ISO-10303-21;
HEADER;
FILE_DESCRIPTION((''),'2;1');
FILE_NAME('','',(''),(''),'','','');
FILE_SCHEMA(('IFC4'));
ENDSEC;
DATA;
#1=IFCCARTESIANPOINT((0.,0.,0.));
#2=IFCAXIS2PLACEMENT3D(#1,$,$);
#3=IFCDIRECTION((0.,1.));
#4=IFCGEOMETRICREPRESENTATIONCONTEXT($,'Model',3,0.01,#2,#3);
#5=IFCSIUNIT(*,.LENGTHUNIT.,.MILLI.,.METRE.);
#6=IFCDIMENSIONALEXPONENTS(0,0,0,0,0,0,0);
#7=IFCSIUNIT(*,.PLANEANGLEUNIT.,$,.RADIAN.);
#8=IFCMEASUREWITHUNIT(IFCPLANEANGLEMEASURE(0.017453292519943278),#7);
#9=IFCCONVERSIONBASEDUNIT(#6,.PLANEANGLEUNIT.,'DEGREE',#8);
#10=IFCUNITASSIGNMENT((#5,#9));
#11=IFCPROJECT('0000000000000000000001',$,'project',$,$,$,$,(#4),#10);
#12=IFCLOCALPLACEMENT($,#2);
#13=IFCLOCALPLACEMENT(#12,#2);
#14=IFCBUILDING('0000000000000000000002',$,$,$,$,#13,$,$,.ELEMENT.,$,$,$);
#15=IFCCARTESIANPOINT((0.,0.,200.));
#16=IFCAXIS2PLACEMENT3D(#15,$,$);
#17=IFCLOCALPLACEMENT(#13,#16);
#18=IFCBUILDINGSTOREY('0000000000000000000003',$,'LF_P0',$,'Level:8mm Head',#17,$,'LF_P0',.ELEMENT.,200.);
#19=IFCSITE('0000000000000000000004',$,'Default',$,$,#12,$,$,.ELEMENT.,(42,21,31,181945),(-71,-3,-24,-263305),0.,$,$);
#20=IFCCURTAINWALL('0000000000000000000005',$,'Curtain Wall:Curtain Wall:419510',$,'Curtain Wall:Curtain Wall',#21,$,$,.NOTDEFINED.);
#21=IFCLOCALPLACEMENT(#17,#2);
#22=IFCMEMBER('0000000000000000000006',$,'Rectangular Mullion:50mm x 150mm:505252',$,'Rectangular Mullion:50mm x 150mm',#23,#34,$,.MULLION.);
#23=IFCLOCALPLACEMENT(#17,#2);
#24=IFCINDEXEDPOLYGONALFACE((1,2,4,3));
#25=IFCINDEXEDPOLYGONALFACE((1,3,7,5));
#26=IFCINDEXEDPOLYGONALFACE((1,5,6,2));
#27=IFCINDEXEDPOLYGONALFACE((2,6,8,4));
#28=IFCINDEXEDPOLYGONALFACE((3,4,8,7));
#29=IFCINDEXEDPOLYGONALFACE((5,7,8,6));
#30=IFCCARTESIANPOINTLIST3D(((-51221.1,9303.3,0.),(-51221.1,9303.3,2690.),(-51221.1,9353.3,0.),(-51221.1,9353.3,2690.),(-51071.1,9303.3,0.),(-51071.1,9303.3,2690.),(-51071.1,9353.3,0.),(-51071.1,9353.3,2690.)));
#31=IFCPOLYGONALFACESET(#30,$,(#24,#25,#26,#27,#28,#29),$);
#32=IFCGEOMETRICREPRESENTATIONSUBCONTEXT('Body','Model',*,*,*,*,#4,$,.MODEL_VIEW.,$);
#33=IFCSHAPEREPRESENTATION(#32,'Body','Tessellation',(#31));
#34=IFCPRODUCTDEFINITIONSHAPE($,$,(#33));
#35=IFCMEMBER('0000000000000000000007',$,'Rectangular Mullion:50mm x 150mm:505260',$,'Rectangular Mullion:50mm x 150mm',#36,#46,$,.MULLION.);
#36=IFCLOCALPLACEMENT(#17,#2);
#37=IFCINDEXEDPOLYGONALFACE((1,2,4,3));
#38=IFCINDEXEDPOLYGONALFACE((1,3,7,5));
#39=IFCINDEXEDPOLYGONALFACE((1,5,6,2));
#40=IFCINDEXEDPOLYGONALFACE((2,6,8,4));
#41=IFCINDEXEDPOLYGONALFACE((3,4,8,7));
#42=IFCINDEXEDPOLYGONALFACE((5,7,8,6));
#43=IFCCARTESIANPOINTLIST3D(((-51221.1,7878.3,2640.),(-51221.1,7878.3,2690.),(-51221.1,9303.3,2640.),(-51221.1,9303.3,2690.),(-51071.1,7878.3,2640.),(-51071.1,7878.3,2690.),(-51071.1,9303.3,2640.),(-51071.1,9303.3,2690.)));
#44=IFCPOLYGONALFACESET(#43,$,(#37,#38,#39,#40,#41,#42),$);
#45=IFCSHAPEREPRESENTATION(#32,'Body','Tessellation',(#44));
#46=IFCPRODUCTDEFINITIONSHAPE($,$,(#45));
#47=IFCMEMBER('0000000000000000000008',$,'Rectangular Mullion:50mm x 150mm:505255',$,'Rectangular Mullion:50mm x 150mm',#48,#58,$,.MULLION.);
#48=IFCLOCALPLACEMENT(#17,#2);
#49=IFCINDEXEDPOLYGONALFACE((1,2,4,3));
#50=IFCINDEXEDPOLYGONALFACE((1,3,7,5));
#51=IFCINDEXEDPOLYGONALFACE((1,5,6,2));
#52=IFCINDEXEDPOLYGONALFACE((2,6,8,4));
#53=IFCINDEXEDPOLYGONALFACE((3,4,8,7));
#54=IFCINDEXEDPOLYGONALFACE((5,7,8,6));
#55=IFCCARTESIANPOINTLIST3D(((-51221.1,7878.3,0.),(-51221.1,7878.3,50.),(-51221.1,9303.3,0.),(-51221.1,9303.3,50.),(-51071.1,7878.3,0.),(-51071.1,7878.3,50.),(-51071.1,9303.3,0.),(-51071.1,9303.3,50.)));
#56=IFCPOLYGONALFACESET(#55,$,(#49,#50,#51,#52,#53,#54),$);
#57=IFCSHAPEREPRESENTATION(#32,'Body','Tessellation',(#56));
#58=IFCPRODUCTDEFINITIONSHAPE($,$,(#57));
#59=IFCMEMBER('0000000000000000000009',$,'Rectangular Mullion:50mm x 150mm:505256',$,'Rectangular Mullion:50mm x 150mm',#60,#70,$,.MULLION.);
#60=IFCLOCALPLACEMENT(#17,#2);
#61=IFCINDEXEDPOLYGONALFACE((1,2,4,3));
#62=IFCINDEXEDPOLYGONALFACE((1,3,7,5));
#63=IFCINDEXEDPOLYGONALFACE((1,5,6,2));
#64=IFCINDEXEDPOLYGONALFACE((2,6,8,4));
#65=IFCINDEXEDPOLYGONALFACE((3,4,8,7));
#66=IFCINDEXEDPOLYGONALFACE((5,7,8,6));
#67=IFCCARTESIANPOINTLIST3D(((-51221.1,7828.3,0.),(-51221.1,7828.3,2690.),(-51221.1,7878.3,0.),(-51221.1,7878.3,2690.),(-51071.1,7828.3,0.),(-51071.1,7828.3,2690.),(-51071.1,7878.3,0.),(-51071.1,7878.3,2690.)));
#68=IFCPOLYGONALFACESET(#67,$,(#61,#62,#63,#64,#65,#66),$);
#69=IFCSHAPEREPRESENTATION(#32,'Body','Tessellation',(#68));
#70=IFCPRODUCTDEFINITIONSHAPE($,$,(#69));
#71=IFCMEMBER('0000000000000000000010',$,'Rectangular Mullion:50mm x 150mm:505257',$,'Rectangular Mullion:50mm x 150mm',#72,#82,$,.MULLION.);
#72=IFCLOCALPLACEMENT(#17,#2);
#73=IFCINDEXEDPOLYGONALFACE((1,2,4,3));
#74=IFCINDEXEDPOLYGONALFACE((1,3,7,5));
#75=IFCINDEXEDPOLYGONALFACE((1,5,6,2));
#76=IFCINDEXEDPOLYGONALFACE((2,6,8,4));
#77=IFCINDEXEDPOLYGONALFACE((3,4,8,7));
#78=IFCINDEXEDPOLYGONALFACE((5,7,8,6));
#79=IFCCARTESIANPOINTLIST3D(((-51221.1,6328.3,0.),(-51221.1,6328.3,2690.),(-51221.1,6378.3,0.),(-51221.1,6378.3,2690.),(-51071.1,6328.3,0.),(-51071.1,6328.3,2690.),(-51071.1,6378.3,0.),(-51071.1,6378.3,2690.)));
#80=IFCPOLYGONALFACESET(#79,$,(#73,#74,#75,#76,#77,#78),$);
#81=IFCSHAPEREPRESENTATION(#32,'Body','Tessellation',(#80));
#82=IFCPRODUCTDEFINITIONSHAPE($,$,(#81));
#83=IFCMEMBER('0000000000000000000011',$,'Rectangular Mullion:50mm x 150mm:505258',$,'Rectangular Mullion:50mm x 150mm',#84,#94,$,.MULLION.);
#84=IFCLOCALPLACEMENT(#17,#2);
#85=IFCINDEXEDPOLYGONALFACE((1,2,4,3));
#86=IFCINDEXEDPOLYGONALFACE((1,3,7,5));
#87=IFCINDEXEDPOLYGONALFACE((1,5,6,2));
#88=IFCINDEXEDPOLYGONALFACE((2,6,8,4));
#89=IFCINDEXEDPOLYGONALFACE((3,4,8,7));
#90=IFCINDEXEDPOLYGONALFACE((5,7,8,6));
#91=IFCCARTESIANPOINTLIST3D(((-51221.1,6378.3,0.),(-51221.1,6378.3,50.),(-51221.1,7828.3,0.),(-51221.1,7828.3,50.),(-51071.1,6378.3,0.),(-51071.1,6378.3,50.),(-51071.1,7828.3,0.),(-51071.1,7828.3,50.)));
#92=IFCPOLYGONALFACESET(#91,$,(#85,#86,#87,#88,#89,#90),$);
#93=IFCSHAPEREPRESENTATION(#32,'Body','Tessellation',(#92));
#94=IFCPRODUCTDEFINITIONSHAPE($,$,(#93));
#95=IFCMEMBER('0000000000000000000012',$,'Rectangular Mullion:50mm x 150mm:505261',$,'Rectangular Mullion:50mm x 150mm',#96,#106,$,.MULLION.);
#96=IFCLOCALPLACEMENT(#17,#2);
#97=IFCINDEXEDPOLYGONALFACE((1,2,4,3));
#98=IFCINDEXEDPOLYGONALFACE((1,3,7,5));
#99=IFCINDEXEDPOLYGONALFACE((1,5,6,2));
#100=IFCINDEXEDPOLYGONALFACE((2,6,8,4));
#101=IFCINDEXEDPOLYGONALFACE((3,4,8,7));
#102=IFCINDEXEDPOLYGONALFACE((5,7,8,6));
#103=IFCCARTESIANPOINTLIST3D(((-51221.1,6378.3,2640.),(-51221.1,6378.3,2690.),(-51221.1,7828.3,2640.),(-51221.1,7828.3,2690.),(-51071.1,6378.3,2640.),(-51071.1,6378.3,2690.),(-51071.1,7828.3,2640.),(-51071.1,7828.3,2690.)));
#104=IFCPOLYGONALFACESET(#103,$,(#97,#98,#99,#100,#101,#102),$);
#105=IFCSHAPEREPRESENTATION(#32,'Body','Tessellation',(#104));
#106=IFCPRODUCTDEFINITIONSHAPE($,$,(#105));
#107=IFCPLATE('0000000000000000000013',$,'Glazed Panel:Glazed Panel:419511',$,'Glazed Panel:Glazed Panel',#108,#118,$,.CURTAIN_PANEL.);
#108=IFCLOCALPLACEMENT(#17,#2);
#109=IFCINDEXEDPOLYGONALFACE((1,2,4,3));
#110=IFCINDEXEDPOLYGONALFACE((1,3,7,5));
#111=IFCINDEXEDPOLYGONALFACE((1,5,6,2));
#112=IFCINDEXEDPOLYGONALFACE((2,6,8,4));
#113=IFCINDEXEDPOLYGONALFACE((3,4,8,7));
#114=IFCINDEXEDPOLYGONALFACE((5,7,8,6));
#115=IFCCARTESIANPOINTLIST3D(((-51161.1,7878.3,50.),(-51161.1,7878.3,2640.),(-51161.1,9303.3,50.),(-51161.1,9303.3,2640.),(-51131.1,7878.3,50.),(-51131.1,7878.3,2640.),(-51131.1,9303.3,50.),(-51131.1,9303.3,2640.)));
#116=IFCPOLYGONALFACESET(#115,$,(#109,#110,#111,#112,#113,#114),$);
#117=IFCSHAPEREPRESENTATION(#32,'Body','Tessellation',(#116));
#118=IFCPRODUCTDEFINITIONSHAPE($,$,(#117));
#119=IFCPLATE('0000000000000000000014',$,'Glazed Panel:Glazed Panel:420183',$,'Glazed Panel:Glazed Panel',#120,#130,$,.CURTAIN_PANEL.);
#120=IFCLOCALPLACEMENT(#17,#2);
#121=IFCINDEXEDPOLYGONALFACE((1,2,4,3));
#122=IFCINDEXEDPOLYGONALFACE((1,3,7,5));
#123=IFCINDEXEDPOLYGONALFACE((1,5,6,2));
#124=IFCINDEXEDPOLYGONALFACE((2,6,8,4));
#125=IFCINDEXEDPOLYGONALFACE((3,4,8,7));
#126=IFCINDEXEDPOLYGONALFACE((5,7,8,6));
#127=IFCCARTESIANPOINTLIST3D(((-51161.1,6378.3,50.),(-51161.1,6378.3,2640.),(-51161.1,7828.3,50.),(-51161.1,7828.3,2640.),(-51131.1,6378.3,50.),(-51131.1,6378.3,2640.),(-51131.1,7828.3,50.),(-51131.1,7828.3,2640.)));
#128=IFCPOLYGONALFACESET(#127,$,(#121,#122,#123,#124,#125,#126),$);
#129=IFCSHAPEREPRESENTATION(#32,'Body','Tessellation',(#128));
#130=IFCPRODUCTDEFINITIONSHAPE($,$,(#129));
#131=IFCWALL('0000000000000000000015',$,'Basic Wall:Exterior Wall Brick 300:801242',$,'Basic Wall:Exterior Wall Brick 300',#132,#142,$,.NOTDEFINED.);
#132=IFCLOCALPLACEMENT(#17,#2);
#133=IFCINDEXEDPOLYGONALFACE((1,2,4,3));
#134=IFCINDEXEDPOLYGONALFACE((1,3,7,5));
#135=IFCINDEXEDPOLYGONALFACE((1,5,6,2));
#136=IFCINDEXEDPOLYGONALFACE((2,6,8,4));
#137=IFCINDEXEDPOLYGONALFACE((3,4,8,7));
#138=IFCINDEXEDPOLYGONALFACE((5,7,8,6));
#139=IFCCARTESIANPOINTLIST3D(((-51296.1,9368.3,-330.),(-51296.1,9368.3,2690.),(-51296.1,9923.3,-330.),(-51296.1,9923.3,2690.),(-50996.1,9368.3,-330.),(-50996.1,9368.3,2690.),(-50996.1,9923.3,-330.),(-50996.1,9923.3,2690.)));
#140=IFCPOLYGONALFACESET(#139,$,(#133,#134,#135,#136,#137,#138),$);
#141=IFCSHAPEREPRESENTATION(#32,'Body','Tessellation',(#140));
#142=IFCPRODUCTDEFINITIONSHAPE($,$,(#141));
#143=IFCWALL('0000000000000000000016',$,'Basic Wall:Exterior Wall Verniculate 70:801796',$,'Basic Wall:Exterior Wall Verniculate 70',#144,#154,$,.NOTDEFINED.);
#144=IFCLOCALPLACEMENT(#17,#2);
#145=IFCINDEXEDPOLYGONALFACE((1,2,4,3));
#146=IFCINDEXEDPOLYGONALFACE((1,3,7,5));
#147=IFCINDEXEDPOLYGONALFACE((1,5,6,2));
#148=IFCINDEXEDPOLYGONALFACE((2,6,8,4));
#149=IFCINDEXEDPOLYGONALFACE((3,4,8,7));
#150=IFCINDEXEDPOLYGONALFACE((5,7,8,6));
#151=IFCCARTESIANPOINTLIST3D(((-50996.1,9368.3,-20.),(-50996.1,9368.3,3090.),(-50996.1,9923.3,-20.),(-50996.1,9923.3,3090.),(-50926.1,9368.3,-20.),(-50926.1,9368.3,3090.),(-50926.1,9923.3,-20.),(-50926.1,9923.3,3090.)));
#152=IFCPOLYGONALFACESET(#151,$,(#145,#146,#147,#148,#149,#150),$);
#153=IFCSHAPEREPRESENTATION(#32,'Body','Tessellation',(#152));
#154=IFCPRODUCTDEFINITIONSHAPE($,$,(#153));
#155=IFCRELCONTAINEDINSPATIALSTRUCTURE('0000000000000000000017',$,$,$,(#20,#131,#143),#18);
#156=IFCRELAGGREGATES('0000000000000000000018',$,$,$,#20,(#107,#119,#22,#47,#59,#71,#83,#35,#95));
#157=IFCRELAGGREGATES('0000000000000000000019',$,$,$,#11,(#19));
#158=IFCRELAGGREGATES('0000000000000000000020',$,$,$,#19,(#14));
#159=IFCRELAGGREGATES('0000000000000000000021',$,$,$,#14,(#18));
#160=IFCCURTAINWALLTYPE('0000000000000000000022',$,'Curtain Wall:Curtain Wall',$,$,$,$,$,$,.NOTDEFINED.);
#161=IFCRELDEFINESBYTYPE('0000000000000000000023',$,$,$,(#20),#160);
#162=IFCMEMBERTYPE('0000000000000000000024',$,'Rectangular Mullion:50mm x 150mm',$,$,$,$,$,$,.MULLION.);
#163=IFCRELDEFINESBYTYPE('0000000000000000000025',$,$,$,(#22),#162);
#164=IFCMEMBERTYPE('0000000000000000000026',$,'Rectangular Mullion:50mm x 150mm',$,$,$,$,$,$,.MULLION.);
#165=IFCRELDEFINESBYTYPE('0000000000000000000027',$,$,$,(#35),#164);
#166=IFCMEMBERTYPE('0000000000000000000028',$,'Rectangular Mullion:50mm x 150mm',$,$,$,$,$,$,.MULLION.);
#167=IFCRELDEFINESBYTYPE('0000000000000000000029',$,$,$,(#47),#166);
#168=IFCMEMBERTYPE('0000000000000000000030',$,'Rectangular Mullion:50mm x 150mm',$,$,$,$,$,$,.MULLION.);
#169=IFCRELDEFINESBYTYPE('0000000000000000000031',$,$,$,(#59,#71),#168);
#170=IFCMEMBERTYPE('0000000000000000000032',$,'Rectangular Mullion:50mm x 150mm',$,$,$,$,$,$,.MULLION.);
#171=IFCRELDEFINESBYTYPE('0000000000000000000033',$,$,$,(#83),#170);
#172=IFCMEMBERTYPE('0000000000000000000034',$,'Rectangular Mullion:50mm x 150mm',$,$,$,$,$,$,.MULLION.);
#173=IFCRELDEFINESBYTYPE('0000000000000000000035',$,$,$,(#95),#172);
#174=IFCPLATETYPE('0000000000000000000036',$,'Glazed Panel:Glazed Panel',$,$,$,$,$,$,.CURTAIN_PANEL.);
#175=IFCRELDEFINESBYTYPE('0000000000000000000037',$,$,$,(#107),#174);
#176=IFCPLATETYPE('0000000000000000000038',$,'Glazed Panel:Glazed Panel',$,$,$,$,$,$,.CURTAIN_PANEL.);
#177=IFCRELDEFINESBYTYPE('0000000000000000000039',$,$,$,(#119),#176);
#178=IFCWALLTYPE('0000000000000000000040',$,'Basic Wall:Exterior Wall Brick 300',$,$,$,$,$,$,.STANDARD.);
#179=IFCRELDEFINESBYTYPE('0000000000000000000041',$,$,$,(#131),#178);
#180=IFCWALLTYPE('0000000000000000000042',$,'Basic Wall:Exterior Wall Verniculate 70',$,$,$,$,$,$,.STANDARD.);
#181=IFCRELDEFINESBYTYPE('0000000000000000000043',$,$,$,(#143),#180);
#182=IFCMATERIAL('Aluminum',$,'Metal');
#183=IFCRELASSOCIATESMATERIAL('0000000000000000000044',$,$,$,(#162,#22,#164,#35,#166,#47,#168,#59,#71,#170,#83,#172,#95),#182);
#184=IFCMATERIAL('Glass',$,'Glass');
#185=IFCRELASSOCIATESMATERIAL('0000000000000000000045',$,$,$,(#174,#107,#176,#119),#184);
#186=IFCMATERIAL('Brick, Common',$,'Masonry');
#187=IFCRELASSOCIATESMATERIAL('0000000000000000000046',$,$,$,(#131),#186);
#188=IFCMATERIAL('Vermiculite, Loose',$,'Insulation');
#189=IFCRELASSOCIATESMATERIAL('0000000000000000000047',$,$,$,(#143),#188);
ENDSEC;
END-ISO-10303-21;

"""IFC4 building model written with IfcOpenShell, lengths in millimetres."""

from ifc_helpers import new_model, entity, si_unit, converted_unit, direction, frame, origin, place, context, subcontext, project, spatial, indexed_curve, outline, extrude, source, transform, mapped, material, type_object, type_shapes, element, aggregate, save


model = new_model("IFC4")

# Units and contexts
model_context = context("Model", 3, precision=0.01, world=origin(), true_north=direction((0.0, 1.0)))
body_context = subcontext(model_context, "Body", "Model", "MODEL_VIEW")
ifc_project = project(units=[si_unit("LENGTHUNIT", "METRE", prefix="MILLI"), converted_unit("PLANEANGLEUNIT", "DEGREE", entity("IfcPlaneAngleMeasure", 0.017453292519943278), si_unit("PLANEANGLEUNIT", "RADIAN"), dimensions=[0, 0, 0, 0, 0, 0, 0])], contexts=[model_context])

# Site, building, storey
site_placement = place(None, origin())
site = spatial("IfcSite", under=ifc_project, at=site_placement, Name="Default", CompositionType="ELEMENT", RefLatitude=(42, 21, 31, 181945), RefLongitude=(-71, -3, -24, -263305), RefElevation=0.0)
building_placement = place(site_placement, origin())
building = spatial("IfcBuilding", under=site, at=building_placement, CompositionType="ELEMENT")
storey_placement = place(building_placement, frame((0.0, 0.0, 200.0)))
storey = spatial("IfcBuildingStorey", under=building, at=storey_placement, Name="LF_P0", ObjectType="Level:8mm Head", LongName="LF_P0", CompositionType="ELEMENT", Elevation=200.0)

# Curtain wall, members, plates
curtain_wall_type = type_object("IfcCurtainWallType", Name="Curtain Wall:Curtain Wall", PredefinedType="NOTDEFINED")
curtain_wall_placement = place(storey_placement, frame((0.0, 0.0, -200.0)))
curtain_wall = element("IfcCurtainWall", 1, at=curtain_wall_placement, inside=storey, type_object=curtain_wall_type, Name="Curtain Wall:Curtain Wall:419510", ObjectType="Curtain Wall:Curtain Wall", PredefinedType="NOTDEFINED")
ifc_material_1 = material(Name="Aluminum", Category="Metal")
member_type_1 = type_object("IfcMemberType", Name="Rectangular Mullion:50mm x 150mm", PredefinedType="MULLION", material=ifc_material_1)
shared_shape_1 = source(origin(), body_context, "Body", "SweptSolid", [
    extrude(outline(indexed_curve([(-25.0, -75.0), (25.0, -75.0), (25.0, 75.0), (-25.0, 75.0), (-25.0, -75.0)], self_intersect=False)), frame((-25.0, 0.0, -2690.0), z_axis=(0.0, 0.0, 1.0), x_axis=(-1.0, 0.0, 0.0)), (0.0, 0.0, 1.0), 2690.0),
])
type_shapes(member_type_1, [shared_shape_1])
member_1_placement = place(curtain_wall_placement, frame((-51146.1, 9353.3, 2890.0), z_axis=(0.0, 0.0, 1.0), x_axis=(0.0, 1.0, 0.0)))
member_1 = element("IfcMember", 2, at=member_1_placement, type_object=member_type_1, material=ifc_material_1, Name="Rectangular Mullion:50mm x 150mm:505252", ObjectType="Rectangular Mullion:50mm x 150mm", PredefinedType="MULLION", context=body_context, shape_type="MappedRepresentation", body=[
    mapped(shared_shape_1, transform((0.0, 0.0, 0.0), scale=1.0)),
])
member_type_2 = type_object("IfcMemberType", Name="Rectangular Mullion:50mm x 150mm", PredefinedType="MULLION", material=ifc_material_1)
shared_shape_2 = source(origin(), body_context, "Body", "SweptSolid", [
    extrude(outline(indexed_curve([(-25.0, -75.0), (25.0, -75.0), (25.0, 75.0), (-25.0, 75.0), (-25.0, -75.0)], self_intersect=False)), frame((-25.0, 0.0, -1425.0), z_axis=(0.0, 0.0, 1.0), x_axis=(-1.0, 0.0, 0.0)), (0.0, 0.0, 1.0), 1425.0),
])
type_shapes(member_type_2, [shared_shape_2])
member_2_placement = place(curtain_wall_placement, frame((-51146.1, 7878.3, 2890.0), z_axis=(0.0, -1.0, 0.0), x_axis=(0.0, 0.0, 1.0)))
member_2 = element("IfcMember", 3, at=member_2_placement, type_object=member_type_2, material=ifc_material_1, Name="Rectangular Mullion:50mm x 150mm:505260", ObjectType="Rectangular Mullion:50mm x 150mm", PredefinedType="MULLION", context=body_context, shape_type="MappedRepresentation", body=[
    mapped(shared_shape_2, transform((0.0, 0.0, 0.0), scale=1.0)),
])
member_type_3 = type_object("IfcMemberType", Name="Rectangular Mullion:50mm x 150mm", PredefinedType="MULLION", material=ifc_material_1)
shared_shape_3 = source(origin(), body_context, "Body", "SweptSolid", [
    extrude(outline(indexed_curve([(-25.0, -75.0), (25.0, -75.0), (25.0, 75.0), (-25.0, 75.0), (-25.0, -75.0)], self_intersect=False)), frame((-25.0, 0.0, -1425.0), z_axis=(0.0, 0.0, 1.0), x_axis=(-1.0, 0.0, 0.0)), (0.0, 0.0, 1.0), 1425.0),
])
type_shapes(member_type_3, [shared_shape_3])
member_3_placement = place(curtain_wall_placement, frame((-51146.1, 9303.3, 200.0), z_axis=(0.0, 1.0, 0.0), x_axis=(0.0, 0.0, -1.0)))
member_3 = element("IfcMember", 4, at=member_3_placement, type_object=member_type_3, material=ifc_material_1, Name="Rectangular Mullion:50mm x 150mm:505255", ObjectType="Rectangular Mullion:50mm x 150mm", PredefinedType="MULLION", context=body_context, shape_type="MappedRepresentation", body=[
    mapped(shared_shape_3, transform((0.0, 0.0, 0.0), scale=1.0)),
])
member_type_4 = type_object("IfcMemberType", Name="Rectangular Mullion:50mm x 150mm", PredefinedType="MULLION", material=ifc_material_1)
shared_shape_4 = source(origin(), body_context, "Body", "SweptSolid", [
    extrude(outline(indexed_curve([(-25.0, -75.0), (25.0, -75.0), (25.0, 75.0), (-25.0, 75.0), (-25.0, -75.0)], self_intersect=False)), frame((0.0, 0.0, -2690.0), z_axis=(0.0, 0.0, 1.0), x_axis=(-1.0, 0.0, 0.0)), (0.0, 0.0, 1.0), 2690.0),
])
type_shapes(member_type_4, [shared_shape_4])
member_4_placement = place(curtain_wall_placement, frame((-51146.1, 7853.3, 200.0), z_axis=(0.0, 0.0, -1.0), x_axis=(0.0, -1.0, 0.0)))
member_4 = element("IfcMember", 5, at=member_4_placement, type_object=member_type_4, material=ifc_material_1, Name="Rectangular Mullion:50mm x 150mm:505256", ObjectType="Rectangular Mullion:50mm x 150mm", PredefinedType="MULLION", context=body_context, shape_type="MappedRepresentation", body=[
    mapped(shared_shape_4, transform((0.0, 0.0, 0.0), scale=1.0)),
])
member_5_placement = place(curtain_wall_placement, frame((-51146.1, 6353.3, 200.0), z_axis=(0.0, 0.0, -1.0), x_axis=(0.0, -1.0, 0.0)))
member_5 = element("IfcMember", 6, at=member_5_placement, type_object=member_type_4, material=ifc_material_1, Name="Rectangular Mullion:50mm x 150mm:505257", ObjectType="Rectangular Mullion:50mm x 150mm", PredefinedType="MULLION", context=body_context, shape_type="MappedRepresentation", body=[
    mapped(shared_shape_4, transform((0.0, 0.0, 0.0), scale=1.0)),
])
member_type_5 = type_object("IfcMemberType", Name="Rectangular Mullion:50mm x 150mm", PredefinedType="MULLION", material=ifc_material_1)
shared_shape_5 = source(origin(), body_context, "Body", "SweptSolid", [
    extrude(outline(indexed_curve([(-25.0, -75.0), (25.0, -75.0), (25.0, 75.0), (-25.0, 75.0), (-25.0, -75.0)], self_intersect=False)), frame((-25.0, 0.0, -1450.0), z_axis=(0.0, 0.0, 1.0), x_axis=(-1.0, 0.0, 0.0)), (0.0, 0.0, 1.0), 1450.0),
])
type_shapes(member_type_5, [shared_shape_5])
member_6_placement = place(curtain_wall_placement, frame((-51146.1, 7828.3, 200.0), z_axis=(0.0, 1.0, 0.0), x_axis=(0.0, 0.0, -1.0)))
member_6 = element("IfcMember", 7, at=member_6_placement, type_object=member_type_5, material=ifc_material_1, Name="Rectangular Mullion:50mm x 150mm:505258", ObjectType="Rectangular Mullion:50mm x 150mm", PredefinedType="MULLION", context=body_context, shape_type="MappedRepresentation", body=[
    mapped(shared_shape_5, transform((0.0, 0.0, 0.0), scale=1.0)),
])
member_type_6 = type_object("IfcMemberType", Name="Rectangular Mullion:50mm x 150mm", PredefinedType="MULLION", material=ifc_material_1)
shared_shape_6 = source(origin(), body_context, "Body", "SweptSolid", [
    extrude(outline(indexed_curve([(-25.0, -75.0), (25.0, -75.0), (25.0, 75.0), (-25.0, 75.0), (-25.0, -75.0)], self_intersect=False)), frame((-25.0, 0.0, -1450.0), z_axis=(0.0, 0.0, 1.0), x_axis=(-1.0, 0.0, 0.0)), (0.0, 0.0, 1.0), 1450.0),
])
type_shapes(member_type_6, [shared_shape_6])
member_7_placement = place(curtain_wall_placement, frame((-51146.1, 6378.3, 2890.0), z_axis=(0.0, -1.0, 0.0), x_axis=(0.0, 0.0, 1.0)))
member_7 = element("IfcMember", 8, at=member_7_placement, type_object=member_type_6, material=ifc_material_1, Name="Rectangular Mullion:50mm x 150mm:505261", ObjectType="Rectangular Mullion:50mm x 150mm", PredefinedType="MULLION", context=body_context, shape_type="MappedRepresentation", body=[
    mapped(shared_shape_6, transform((0.0, 0.0, 0.0), scale=1.0)),
])
ifc_material_2 = material(Name="Glass", Category="Glass")
plate_type_1 = type_object("IfcPlateType", Name="Glazed Panel:Glazed Panel", PredefinedType="CURTAIN_PANEL", material=ifc_material_2)
shared_shape_7 = source(origin(), body_context, "Body", "SweptSolid", [
    extrude(outline(indexed_curve([(-712.5, -15.0), (712.5, -15.0), (712.5, 15.0), (-712.5, 15.0), (-712.5, -15.0)], self_intersect=False)), frame((0.0, 0.0, 0.0), z_axis=(0.0, 0.0, 1.0), x_axis=(-1.0, 0.0, 0.0)), (0.0, 0.0, 1.0), 2590.0),
])
type_shapes(plate_type_1, [shared_shape_7])
plate_1_placement = place(curtain_wall_placement, frame((-51146.1, 8590.8, 250.0), z_axis=(0.0, 0.0, 1.0), x_axis=(0.0, -1.0, 0.0)))
plate_1 = element("IfcPlate", 9, at=plate_1_placement, type_object=plate_type_1, material=ifc_material_2, Name="Glazed Panel:Glazed Panel:419511", ObjectType="Glazed Panel:Glazed Panel", PredefinedType="CURTAIN_PANEL", context=body_context, shape_type="MappedRepresentation", body=[
    mapped(shared_shape_7, transform((0.0, 0.0, 0.0), scale=1.0)),
])
plate_type_2 = type_object("IfcPlateType", Name="Glazed Panel:Glazed Panel", PredefinedType="CURTAIN_PANEL", material=ifc_material_2)
shared_shape_8 = source(origin(), body_context, "Body", "SweptSolid", [
    extrude(outline(indexed_curve([(-725.0, -15.0), (725.0, -15.0), (725.0, 15.0), (-725.0, 15.0), (-725.0, -15.0)], self_intersect=False)), frame((0.0, 0.0, 0.0), z_axis=(0.0, 0.0, 1.0), x_axis=(-1.0, 0.0, 0.0)), (0.0, 0.0, 1.0), 2590.0),
])
type_shapes(plate_type_2, [shared_shape_8])
plate_2_placement = place(curtain_wall_placement, frame((-51146.1, 7103.3, 250.0), z_axis=(0.0, 0.0, 1.0), x_axis=(0.0, -1.0, 0.0)))
plate_2 = element("IfcPlate", 10, at=plate_2_placement, type_object=plate_type_2, material=ifc_material_2, Name="Glazed Panel:Glazed Panel:420183", ObjectType="Glazed Panel:Glazed Panel", PredefinedType="CURTAIN_PANEL", context=body_context, shape_type="MappedRepresentation", body=[
    mapped(shared_shape_8, transform((0.0, 0.0, 0.0), scale=1.0)),
])
aggregate(curtain_wall, [plate_1, plate_2, member_1, member_3, member_4, member_5, member_6, member_2, member_7])

# Walls
ifc_material_3 = material(Name="Brick, Common", Category="Masonry")
wall_type_1 = type_object("IfcWallType", Name="Basic Wall:Exterior Wall Brick 300", PredefinedType="STANDARD")
wall_1_placement = place(storey_placement, frame((-51146.1, 9923.3, -330.0), z_axis=(0.0, 0.0, 1.0), x_axis=(0.0, -1.0, 0.0)))
element("IfcWall", 11, at=wall_1_placement, inside=storey, type_object=wall_type_1, material=ifc_material_3, Name="Basic Wall:Exterior Wall Brick 300:801242", ObjectType="Basic Wall:Exterior Wall Brick 300", PredefinedType="NOTDEFINED", context=body_context, shape_type="SweptSolid", body=[
    extrude(outline(indexed_curve([(555.0, 150.0), (0.0, 150.0), (0.0, -150.0), (555.0, -150.0), (555.0, 150.0)], self_intersect=False)), origin(), (0.0, 0.0, 1.0), 3020.0),
])
ifc_material_4 = material(Name="Vermiculite, Loose", Category="Insulation")
wall_type_2 = type_object("IfcWallType", Name="Basic Wall:Exterior Wall Verniculate 70", PredefinedType="STANDARD")
wall_2_placement = place(storey_placement, frame((-50961.1, 9923.3, -20.0), z_axis=(0.0, 0.0, 1.0), x_axis=(0.0, -1.0, 0.0)))
element("IfcWall", 12, at=wall_2_placement, inside=storey, type_object=wall_type_2, material=ifc_material_4, Name="Basic Wall:Exterior Wall Verniculate 70:801796", ObjectType="Basic Wall:Exterior Wall Verniculate 70", PredefinedType="NOTDEFINED", context=body_context, shape_type="SweptSolid", body=[
    extrude(outline(indexed_curve([(555.0, 35.0), (0.0, 35.0), (0.0, -35.0), (555.0, -35.0), (555.0, 35.0)], self_intersect=False)), origin(), (0.0, 0.0, 1.0), 3110.0),
])

save(model, "model.ifc")
